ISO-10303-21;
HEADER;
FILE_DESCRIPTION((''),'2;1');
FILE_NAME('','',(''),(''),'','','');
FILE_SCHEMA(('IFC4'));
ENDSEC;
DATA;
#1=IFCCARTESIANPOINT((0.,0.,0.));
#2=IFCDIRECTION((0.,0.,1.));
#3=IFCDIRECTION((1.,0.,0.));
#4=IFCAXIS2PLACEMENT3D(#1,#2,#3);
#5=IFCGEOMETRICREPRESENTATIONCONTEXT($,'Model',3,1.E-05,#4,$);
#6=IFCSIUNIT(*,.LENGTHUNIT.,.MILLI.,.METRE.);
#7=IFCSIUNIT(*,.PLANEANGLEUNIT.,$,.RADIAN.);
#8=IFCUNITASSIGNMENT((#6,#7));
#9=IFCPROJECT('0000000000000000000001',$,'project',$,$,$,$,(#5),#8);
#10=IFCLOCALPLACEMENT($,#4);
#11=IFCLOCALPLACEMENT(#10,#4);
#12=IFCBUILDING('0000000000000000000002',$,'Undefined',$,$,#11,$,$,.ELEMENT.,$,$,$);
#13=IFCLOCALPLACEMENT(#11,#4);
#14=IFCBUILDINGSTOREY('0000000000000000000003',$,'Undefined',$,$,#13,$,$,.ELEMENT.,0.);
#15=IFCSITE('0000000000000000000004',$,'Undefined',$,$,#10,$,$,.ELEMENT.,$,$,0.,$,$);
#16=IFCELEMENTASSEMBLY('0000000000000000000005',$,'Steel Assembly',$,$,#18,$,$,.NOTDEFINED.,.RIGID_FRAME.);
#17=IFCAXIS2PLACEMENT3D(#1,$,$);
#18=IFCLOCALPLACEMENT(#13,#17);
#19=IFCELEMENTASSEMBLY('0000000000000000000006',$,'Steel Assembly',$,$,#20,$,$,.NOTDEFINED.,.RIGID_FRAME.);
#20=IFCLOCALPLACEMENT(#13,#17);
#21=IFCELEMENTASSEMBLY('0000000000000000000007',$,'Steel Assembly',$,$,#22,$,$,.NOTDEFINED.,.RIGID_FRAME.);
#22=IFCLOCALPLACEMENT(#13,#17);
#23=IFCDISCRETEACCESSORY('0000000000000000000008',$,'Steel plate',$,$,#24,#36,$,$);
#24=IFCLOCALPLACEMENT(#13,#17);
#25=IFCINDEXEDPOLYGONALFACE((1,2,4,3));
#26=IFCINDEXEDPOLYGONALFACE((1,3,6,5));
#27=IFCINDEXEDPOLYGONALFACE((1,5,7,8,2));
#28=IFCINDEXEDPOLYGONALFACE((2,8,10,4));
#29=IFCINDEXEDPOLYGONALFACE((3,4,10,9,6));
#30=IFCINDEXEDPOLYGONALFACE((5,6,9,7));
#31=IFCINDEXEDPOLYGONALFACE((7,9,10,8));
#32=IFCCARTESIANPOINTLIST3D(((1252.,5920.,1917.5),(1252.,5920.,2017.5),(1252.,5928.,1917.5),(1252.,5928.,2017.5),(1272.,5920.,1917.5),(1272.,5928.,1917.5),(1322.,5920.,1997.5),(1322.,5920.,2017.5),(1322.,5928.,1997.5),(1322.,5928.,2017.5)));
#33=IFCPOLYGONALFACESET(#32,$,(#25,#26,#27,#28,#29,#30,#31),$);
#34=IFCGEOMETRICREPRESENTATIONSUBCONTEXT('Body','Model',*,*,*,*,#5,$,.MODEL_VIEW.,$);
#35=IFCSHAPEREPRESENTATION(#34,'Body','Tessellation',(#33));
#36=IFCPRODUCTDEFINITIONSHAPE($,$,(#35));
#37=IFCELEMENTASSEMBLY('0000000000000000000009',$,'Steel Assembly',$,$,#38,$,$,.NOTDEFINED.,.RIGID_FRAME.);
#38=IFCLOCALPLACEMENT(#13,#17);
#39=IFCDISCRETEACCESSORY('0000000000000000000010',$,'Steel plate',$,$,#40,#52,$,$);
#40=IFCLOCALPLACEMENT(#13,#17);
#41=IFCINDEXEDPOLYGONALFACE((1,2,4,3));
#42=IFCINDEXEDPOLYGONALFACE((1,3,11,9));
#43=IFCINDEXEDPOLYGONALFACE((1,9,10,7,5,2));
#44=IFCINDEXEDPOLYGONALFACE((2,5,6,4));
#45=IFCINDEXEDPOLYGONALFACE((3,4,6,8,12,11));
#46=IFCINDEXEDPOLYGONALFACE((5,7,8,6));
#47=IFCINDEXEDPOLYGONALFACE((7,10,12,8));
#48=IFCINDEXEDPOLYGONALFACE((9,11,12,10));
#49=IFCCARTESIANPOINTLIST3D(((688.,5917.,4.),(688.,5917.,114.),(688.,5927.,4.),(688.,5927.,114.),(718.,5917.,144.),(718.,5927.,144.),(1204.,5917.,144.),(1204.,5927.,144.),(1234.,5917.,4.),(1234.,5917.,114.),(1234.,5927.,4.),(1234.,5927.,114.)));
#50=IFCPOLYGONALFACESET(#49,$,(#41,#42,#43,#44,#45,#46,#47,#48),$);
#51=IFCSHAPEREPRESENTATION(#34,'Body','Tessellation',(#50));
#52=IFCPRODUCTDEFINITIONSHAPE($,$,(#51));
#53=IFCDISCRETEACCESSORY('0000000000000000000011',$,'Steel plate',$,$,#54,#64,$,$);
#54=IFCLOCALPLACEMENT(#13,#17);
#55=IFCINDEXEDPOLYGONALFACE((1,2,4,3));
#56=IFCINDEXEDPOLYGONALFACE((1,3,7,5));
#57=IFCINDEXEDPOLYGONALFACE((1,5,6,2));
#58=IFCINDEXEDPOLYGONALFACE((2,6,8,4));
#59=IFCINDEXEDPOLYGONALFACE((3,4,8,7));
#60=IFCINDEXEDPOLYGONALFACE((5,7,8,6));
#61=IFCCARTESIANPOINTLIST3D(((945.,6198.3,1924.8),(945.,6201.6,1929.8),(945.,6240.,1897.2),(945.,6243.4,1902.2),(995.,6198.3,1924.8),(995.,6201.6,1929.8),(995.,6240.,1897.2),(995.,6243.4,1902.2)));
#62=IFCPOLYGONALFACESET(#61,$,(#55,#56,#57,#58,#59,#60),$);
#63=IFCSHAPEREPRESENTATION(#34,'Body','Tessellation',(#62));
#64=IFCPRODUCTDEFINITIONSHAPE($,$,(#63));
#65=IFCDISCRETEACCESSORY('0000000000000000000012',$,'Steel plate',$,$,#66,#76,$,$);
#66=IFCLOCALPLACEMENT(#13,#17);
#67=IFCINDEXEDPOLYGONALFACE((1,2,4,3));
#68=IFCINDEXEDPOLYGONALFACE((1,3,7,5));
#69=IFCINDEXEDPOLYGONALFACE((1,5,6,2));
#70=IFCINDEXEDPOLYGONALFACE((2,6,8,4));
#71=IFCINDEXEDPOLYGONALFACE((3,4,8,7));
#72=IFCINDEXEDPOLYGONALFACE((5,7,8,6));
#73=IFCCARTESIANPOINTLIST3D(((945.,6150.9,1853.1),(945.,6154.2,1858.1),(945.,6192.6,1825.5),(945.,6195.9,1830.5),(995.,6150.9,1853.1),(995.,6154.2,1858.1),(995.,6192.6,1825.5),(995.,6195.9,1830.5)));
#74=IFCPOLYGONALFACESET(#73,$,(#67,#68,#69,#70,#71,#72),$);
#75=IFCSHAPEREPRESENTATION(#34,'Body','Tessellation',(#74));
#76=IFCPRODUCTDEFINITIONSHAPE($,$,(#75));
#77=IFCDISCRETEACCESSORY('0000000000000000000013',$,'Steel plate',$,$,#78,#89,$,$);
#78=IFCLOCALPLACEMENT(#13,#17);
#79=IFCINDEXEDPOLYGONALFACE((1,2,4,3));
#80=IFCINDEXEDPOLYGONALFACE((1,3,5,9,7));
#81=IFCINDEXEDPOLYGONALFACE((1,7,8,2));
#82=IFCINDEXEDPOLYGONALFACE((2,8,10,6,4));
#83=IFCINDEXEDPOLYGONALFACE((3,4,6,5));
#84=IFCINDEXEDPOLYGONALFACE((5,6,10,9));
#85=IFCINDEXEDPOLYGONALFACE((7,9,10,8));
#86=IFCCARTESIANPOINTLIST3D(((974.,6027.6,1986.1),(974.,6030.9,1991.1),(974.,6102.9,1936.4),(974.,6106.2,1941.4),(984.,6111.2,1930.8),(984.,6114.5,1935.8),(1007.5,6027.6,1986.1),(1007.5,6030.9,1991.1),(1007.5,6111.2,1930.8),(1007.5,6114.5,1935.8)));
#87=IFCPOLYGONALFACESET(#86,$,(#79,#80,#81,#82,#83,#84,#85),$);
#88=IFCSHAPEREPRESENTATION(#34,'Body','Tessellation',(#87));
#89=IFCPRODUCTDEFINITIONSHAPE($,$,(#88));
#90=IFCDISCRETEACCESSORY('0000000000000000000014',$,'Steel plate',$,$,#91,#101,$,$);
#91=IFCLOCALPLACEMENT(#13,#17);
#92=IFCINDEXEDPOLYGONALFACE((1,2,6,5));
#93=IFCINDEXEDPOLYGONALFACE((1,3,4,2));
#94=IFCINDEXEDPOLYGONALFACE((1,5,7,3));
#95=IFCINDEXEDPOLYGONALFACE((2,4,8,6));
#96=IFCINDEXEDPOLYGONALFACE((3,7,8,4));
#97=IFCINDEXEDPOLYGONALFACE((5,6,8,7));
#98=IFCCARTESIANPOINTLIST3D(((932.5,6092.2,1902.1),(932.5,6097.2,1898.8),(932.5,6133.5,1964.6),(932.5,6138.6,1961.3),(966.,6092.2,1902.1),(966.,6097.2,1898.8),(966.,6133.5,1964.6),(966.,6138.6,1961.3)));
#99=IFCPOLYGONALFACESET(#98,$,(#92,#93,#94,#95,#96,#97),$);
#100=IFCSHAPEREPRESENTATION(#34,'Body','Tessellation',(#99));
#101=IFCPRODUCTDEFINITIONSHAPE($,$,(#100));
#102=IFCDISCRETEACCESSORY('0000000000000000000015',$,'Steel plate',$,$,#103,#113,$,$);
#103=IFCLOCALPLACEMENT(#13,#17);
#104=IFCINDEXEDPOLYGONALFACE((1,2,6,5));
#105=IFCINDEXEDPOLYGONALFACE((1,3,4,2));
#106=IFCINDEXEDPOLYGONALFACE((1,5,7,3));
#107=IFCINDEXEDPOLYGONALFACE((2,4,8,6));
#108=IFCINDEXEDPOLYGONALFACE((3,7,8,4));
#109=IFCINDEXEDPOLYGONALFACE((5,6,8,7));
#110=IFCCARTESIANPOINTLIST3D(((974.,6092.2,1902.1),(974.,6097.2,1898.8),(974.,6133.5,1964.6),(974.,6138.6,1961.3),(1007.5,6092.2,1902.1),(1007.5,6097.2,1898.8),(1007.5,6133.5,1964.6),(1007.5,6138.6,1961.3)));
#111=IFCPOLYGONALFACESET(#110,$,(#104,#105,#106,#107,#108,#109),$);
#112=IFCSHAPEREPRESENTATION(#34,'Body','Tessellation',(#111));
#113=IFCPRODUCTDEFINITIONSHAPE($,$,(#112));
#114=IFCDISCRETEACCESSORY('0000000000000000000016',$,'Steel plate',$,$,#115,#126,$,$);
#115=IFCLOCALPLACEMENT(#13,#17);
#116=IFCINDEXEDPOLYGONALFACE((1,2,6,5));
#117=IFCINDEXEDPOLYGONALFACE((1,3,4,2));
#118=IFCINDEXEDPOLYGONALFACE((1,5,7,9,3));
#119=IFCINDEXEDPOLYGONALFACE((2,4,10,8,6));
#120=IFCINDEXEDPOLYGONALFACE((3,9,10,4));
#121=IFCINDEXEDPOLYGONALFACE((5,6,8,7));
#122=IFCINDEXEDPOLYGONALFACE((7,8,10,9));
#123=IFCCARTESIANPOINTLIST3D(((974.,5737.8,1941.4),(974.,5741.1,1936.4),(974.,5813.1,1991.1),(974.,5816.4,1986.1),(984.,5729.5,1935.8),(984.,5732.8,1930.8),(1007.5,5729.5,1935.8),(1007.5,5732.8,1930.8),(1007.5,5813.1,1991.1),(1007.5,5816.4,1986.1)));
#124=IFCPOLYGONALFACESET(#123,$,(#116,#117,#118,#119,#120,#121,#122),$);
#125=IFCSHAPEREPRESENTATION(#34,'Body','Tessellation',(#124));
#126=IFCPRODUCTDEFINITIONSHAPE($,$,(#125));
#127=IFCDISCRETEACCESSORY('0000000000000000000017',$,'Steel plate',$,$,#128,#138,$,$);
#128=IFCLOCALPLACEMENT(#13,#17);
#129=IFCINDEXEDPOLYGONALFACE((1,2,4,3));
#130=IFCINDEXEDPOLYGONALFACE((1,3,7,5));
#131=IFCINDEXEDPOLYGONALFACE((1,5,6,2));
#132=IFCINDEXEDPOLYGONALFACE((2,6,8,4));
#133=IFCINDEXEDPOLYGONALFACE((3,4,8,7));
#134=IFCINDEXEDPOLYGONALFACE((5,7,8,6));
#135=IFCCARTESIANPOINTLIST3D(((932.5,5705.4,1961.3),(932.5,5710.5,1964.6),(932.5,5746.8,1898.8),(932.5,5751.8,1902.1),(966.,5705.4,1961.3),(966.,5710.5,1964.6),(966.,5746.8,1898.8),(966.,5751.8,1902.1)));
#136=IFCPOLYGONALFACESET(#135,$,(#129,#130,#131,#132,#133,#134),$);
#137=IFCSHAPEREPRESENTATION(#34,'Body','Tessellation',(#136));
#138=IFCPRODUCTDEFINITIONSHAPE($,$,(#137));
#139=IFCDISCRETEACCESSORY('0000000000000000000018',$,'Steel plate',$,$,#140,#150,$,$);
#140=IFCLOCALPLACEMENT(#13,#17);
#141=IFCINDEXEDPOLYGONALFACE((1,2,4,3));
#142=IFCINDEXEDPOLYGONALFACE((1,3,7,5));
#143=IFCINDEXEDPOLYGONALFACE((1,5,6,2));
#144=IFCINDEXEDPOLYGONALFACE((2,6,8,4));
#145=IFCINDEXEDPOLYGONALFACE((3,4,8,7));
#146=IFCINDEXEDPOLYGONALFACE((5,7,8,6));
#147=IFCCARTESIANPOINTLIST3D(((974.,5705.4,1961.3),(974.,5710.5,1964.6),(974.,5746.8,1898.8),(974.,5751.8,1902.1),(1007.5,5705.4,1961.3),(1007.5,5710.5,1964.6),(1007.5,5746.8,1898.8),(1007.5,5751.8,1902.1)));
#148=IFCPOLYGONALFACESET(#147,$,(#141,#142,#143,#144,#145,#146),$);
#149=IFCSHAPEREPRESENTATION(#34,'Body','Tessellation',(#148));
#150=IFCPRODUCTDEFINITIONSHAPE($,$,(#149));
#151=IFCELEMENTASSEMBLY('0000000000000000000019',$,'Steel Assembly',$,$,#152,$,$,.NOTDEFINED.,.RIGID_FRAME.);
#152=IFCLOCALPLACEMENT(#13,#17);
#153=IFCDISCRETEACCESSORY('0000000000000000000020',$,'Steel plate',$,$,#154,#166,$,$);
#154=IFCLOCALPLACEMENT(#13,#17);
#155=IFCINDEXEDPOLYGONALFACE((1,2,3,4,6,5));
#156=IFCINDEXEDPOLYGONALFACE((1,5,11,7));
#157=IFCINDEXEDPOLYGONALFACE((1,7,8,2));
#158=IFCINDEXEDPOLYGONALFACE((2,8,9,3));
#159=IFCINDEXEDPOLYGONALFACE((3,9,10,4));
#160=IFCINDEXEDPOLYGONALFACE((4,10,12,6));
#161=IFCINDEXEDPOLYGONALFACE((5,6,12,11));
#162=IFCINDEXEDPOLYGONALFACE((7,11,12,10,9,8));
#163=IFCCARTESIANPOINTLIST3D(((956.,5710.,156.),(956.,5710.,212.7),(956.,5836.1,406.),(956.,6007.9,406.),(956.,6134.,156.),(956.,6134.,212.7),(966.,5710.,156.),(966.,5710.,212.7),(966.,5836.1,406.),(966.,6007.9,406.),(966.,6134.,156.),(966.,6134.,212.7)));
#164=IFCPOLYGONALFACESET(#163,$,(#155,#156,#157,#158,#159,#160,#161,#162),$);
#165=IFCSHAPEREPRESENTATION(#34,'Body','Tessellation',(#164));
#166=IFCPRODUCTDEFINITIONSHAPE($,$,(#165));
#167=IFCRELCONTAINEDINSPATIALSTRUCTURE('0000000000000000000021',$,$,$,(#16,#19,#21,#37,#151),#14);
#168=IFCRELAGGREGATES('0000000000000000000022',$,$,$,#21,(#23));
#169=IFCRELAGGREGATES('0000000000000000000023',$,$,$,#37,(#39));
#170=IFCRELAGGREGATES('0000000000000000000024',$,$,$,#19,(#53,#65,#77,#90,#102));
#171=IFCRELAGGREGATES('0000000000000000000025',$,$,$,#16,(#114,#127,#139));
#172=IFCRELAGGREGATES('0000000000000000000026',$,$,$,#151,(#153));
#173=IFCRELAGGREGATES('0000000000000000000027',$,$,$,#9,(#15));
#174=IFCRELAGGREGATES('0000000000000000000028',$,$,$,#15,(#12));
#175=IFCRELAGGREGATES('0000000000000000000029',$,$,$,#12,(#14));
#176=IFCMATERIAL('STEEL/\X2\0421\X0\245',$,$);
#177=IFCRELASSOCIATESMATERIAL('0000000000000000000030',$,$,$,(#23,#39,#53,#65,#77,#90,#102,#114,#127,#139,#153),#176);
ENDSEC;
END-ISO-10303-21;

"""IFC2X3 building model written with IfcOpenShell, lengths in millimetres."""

from ifc_helpers import new_model, si_unit, frame, origin_with_axes, place, context, subcontext, project, spatial, polyline, outline, extrude, material, element, aggregate, save


model = new_model("IFC2X3")

# Units and contexts
model_context = context("Model", 3, precision=1e-05, world=origin_with_axes())
body_context = subcontext(model_context, "Body", "Model", "MODEL_VIEW")
ifc_project = project(units=[si_unit("LENGTHUNIT", "METRE", prefix="MILLI"), si_unit("PLANEANGLEUNIT", "RADIAN")], contexts=[model_context])

# Site, building, storey
site_placement = place(None, origin_with_axes())
site = spatial("IfcSite", under=ifc_project, at=site_placement, Name="Undefined", CompositionType="ELEMENT", RefElevation=0.0)
building_placement = place(site_placement, origin_with_axes())
building = spatial("IfcBuilding", under=site, at=building_placement, Name="Undefined", CompositionType="ELEMENT")
storey_placement = place(building_placement, origin_with_axes())
storey = spatial("IfcBuildingStorey", under=building, at=storey_placement, Name="Undefined", CompositionType="ELEMENT", Elevation=0.0)

# Element assemblies
assembly_1_placement = place(storey_placement, origin_with_axes())
assembly_1 = element("IfcElementAssembly", 1, at=assembly_1_placement, inside=storey, Name="Steel Assembly", AssemblyPlace="NOTDEFINED", PredefinedType="RIGID_FRAME")
assembly_2_placement = place(storey_placement, origin_with_axes())
assembly_2 = element("IfcElementAssembly", 2, at=assembly_2_placement, inside=storey, Name="Steel Assembly", AssemblyPlace="NOTDEFINED", PredefinedType="RIGID_FRAME")

# Element assemblies, discrete accessories
assembly_3_placement = place(storey_placement, origin_with_axes())
assembly_3 = element("IfcElementAssembly", 3, at=assembly_3_placement, inside=storey, Name="Steel Assembly", AssemblyPlace="NOTDEFINED", PredefinedType="RIGID_FRAME")
ifc_material_1 = material(Name="STEEL/С245")
discrete_accessory_1_placement = place(assembly_3_placement, frame((1252.0, 5924.0, 2017.5), z_axis=(0.0, -1.0, 0.0), x_axis=(0.0, 0.0, -1.0)))
discrete_accessory_1 = element("IfcDiscreteAccessory", 4, at=discrete_accessory_1_placement, material=ifc_material_1, Name="Steel plate", context=body_context, shape_type="SweptSolid", body=[
    extrude(outline(polyline([(0.0, 0.0), (100.0, 0.0), (100.0, 20.0), (20.0, 70.0), (0.0, 70.0), (0.0, 0.0)])), frame((0.0, 0.0, -4.0), z_axis=(0.0, 0.0, 1.0), x_axis=(1.0, 0.0, 0.0)), (0.0, 0.0, 1.0), 8.0),
])
aggregate(assembly_3, [discrete_accessory_1])
assembly_4_placement = place(storey_placement, origin_with_axes())
assembly_4 = element("IfcElementAssembly", 5, at=assembly_4_placement, inside=storey, Name="Steel Assembly", AssemblyPlace="NOTDEFINED", PredefinedType="RIGID_FRAME")
discrete_accessory_2_placement = place(assembly_4_placement, frame((688.0, 5922.0, 4.0), z_axis=(0.0, 1.0, 0.0), x_axis=(0.0, 0.0, 1.0)))
discrete_accessory_2 = element("IfcDiscreteAccessory", 6, at=discrete_accessory_2_placement, material=ifc_material_1, Name="Steel plate", context=body_context, shape_type="SweptSolid", body=[
    extrude(outline(polyline([(0.0, 0.0), (110.0, 0.0), (140.0, 30.0), (140.0, 516.0), (110.0, 546.0), (0.0, 546.0), (0.0, 0.0)])), frame((0.0, 0.0, -5.0), z_axis=(0.0, 0.0, 1.0), x_axis=(1.0, 0.0, 0.0)), (0.0, 0.0, 1.0), 10.0),
])
aggregate(assembly_4, [discrete_accessory_2])

# Discrete accessories
discrete_accessory_3_placement = place(assembly_2_placement, frame((995.0, 6200.0, 1927.3), z_axis=(0.0, 0.551387, 0.83425), x_axis=(0.0, 0.83425, -0.551387)))
discrete_accessory_3 = element("IfcDiscreteAccessory", 7, at=discrete_accessory_3_placement, material=ifc_material_1, Name="Steel plate", context=body_context, shape_type="SweptSolid", body=[
    extrude(outline(polyline([(0.0, 0.0), (50.0, 0.0), (50.0, 50.0), (0.0, 50.0), (0.0, 0.0)])), frame((0.0, 0.0, -3.0), z_axis=(0.0, 0.0, 1.0), x_axis=(1.0, 0.0, 0.0)), (0.0, 0.0, 1.0), 6.0),
])
discrete_accessory_4_placement = place(assembly_2_placement, frame((995.0, 6152.6, 1855.6), z_axis=(0.0, 0.551387, 0.83425), x_axis=(0.0, 0.83425, -0.551387)))
discrete_accessory_4 = element("IfcDiscreteAccessory", 8, at=discrete_accessory_4_placement, material=ifc_material_1, Name="Steel plate", context=body_context, shape_type="SweptSolid", body=[
    extrude(outline(polyline([(0.0, 0.0), (50.0, 0.0), (50.0, 50.0), (0.0, 50.0), (0.0, 0.0)])), frame((0.0, 0.0, -3.0), z_axis=(0.0, 0.0, 1.0), x_axis=(1.0, 0.0, 0.0)), (0.0, 0.0, 1.0), 6.0),
])
discrete_accessory_5_placement = place(assembly_2_placement, frame((1007.5, 6029.3, 1988.6), z_axis=(0.0, 0.551387, 0.83425), x_axis=(0.0, 0.83425, -0.551387)))
discrete_accessory_5 = element("IfcDiscreteAccessory", 9, at=discrete_accessory_5_placement, material=ifc_material_1, Name="Steel plate", context=body_context, shape_type="SweptSolid", body=[
    extrude(outline(polyline([(0.0, 0.0), (100.2, 0.0), (100.2, 23.5), (90.2, 33.5), (0.0, 33.5), (0.0, 0.0)])), frame((0.0, 0.0, -3.0), z_axis=(0.0, 0.0, 1.0), x_axis=(1.0, 0.0, 0.0)), (0.0, 0.0, 1.0), 6.0),
])

# Discrete accessories, openings
discrete_accessory_6_placement = place(assembly_2_placement, frame((932.5, 6136.1, 1963.0), z_axis=(0.0, -0.83425, 0.551387), x_axis=(0.0, -0.551387, -0.83425)))
discrete_accessory_6 = element("IfcDiscreteAccessory", 10, at=discrete_accessory_6_placement, material=ifc_material_1, Name="Steel plate", context=body_context, shape_type="SweptSolid", body=[
    extrude(outline(polyline([(0.0, 0.0), (75.0, 0.0), (75.0, 75.0), (0.0, 75.0), (0.0, 0.0)])), frame((0.0, 0.0, -3.0), z_axis=(0.0, 0.0, 1.0), x_axis=(1.0, 0.0, 0.0)), (0.0, 0.0, 1.0), 6.0),
])
opening_1_placement = place(assembly_2_placement, frame((932.5, 6136.1, 1963.0), z_axis=(0.0, -0.83425, 0.551387), x_axis=(0.0, -0.551387, -0.83425)))
element("IfcOpeningElement", 11, at=opening_1_placement, cuts=discrete_accessory_6, ObjectType="Recess", context=body_context, shape_type="SweptSolid", body=[
    extrude(outline(polyline([(0.0, 0.0), (75.0, 0.0), (75.0, 150.0), (0.0, 150.0), (0.0, 0.0)])), frame((112.5, 33.5, -6.0), z_axis=(0.0, 0.0, 1.0), x_axis=(0.0, 1.0, 0.0)), (0.0, 0.0, 1.0), 12.0),
])
discrete_accessory_7_placement = place(assembly_2_placement, frame((1007.5, 6094.7, 1900.4), z_axis=(0.0, -0.83425, 0.551387), x_axis=(0.0, 0.551387, 0.83425)))
discrete_accessory_7 = element("IfcDiscreteAccessory", 12, at=discrete_accessory_7_placement, material=ifc_material_1, Name="Steel plate", context=body_context, shape_type="SweptSolid", body=[
    extrude(outline(polyline([(0.0, 0.0), (75.0, 0.0), (75.0, 75.0), (0.0, 75.0), (0.0, 0.0)])), frame((0.0, 0.0, -3.0), z_axis=(0.0, 0.0, 1.0), x_axis=(1.0, 0.0, 0.0)), (0.0, 0.0, 1.0), 6.0),
])
opening_2_placement = place(assembly_2_placement, frame((1007.5, 6094.7, 1900.4), z_axis=(0.0, -0.83425, 0.551387), x_axis=(0.0, 0.551387, 0.83425)))
element("IfcOpeningElement", 13, at=opening_2_placement, cuts=discrete_accessory_7, ObjectType="Recess", context=body_context, shape_type="SweptSolid", body=[
    extrude(outline(polyline([(0.0, 0.0), (75.0, 0.0), (75.0, 150.0), (0.0, 150.0), (0.0, 0.0)])), frame((112.5, 33.5, -6.0), z_axis=(0.0, 0.0, 1.0), x_axis=(0.0, 1.0, 0.0)), (0.0, 0.0, 1.0), 12.0),
])
aggregate(assembly_2, [discrete_accessory_3, discrete_accessory_4, discrete_accessory_5, discrete_accessory_6, discrete_accessory_7])

# Discrete accessory
discrete_accessory_8_placement = place(assembly_1_placement, frame((1007.5, 5731.1, 1933.3), z_axis=(0.0, -0.551387, 0.83425), x_axis=(0.0, 0.83425, 0.551387)))
discrete_accessory_8 = element("IfcDiscreteAccessory", 14, at=discrete_accessory_8_placement, material=ifc_material_1, Name="Steel plate", context=body_context, shape_type="SweptSolid", body=[
    extrude(outline(polyline([(0.0, 0.0), (100.2, 0.0), (100.2, 33.5), (10.0, 33.5), (0.0, 23.5), (0.0, 0.0)])), frame((0.0, 0.0, -3.0), z_axis=(0.0, 0.0, 1.0), x_axis=(1.0, 0.0, 0.0)), (0.0, 0.0, 1.0), 6.0),
])

# Discrete accessories, openings
discrete_accessory_9_placement = place(assembly_1_placement, frame((932.5, 5749.3, 1900.4), z_axis=(0.0, 0.83425, 0.551387), x_axis=(0.0, -0.551387, 0.83425)))
discrete_accessory_9 = element("IfcDiscreteAccessory", 15, at=discrete_accessory_9_placement, material=ifc_material_1, Name="Steel plate", context=body_context, shape_type="SweptSolid", body=[
    extrude(outline(polyline([(0.0, 0.0), (75.0, 0.0), (75.0, 75.0), (0.0, 75.0), (0.0, 0.0)])), frame((0.0, 0.0, -3.0), z_axis=(0.0, 0.0, 1.0), x_axis=(1.0, 0.0, 0.0)), (0.0, 0.0, 1.0), 6.0),
])
opening_3_placement = place(assembly_1_placement, frame((932.5, 5749.3, 1900.4), z_axis=(0.0, 0.83425, 0.551387), x_axis=(0.0, -0.551387, 0.83425)))
element("IfcOpeningElement", 16, at=opening_3_placement, cuts=discrete_accessory_9, ObjectType="Recess", context=body_context, shape_type="SweptSolid", body=[
    extrude(outline(polyline([(0.0, 0.0), (75.0, 0.0), (75.0, 150.0), (0.0, 150.0), (0.0, 0.0)])), frame((112.5, 33.5, -6.0), z_axis=(0.0, 0.0, 1.0), x_axis=(0.0, 1.0, 0.0)), (0.0, 0.0, 1.0), 12.0),
])
discrete_accessory_10_placement = place(assembly_1_placement, frame((1007.5, 5707.9, 1963.0), z_axis=(0.0, 0.83425, 0.551387), x_axis=(0.0, 0.551387, -0.83425)))
discrete_accessory_10 = element("IfcDiscreteAccessory", 17, at=discrete_accessory_10_placement, material=ifc_material_1, Name="Steel plate", context=body_context, shape_type="SweptSolid", body=[
    extrude(outline(polyline([(0.0, 0.0), (75.0, 0.0), (75.0, 75.0), (0.0, 75.0), (0.0, 0.0)])), frame((0.0, 0.0, -3.0), z_axis=(0.0, 0.0, 1.0), x_axis=(1.0, 0.0, 0.0)), (0.0, 0.0, 1.0), 6.0),
])
opening_4_placement = place(assembly_1_placement, frame((1007.5, 5707.9, 1963.0), z_axis=(0.0, 0.83425, 0.551387), x_axis=(0.0, 0.551387, -0.83425)))
element("IfcOpeningElement", 18, at=opening_4_placement, cuts=discrete_accessory_10, ObjectType="Recess", context=body_context, shape_type="SweptSolid", body=[
    extrude(outline(polyline([(0.0, 0.0), (75.0, 0.0), (75.0, 150.0), (0.0, 150.0), (0.0, 0.0)])), frame((112.5, 33.5, -6.0), z_axis=(0.0, 0.0, 1.0), x_axis=(0.0, 1.0, 0.0)), (0.0, 0.0, 1.0), 12.0),
])
aggregate(assembly_1, [discrete_accessory_8, discrete_accessory_9, discrete_accessory_10])

# Element assembly, discrete accessory
assembly_5_placement = place(storey_placement, origin_with_axes())
assembly_5 = element("IfcElementAssembly", 19, at=assembly_5_placement, inside=storey, Name="Steel Assembly", AssemblyPlace="NOTDEFINED", PredefinedType="RIGID_FRAME")
discrete_accessory_11_placement = place(assembly_5_placement, frame((961.0, 5710.0, 156.0), z_axis=(1.0, 0.0, 0.0), x_axis=(0.0, 1.0, 0.0)))
discrete_accessory_11 = element("IfcDiscreteAccessory", 20, at=discrete_accessory_11_placement, material=ifc_material_1, Name="Steel plate", context=body_context, shape_type="SweptSolid", body=[
    extrude(outline(polyline([(0.0, 0.0), (424.0, 0.0), (424.0, 56.7), (297.9, 250.0), (126.1, 250.0), (0.0, 56.7), (0.0, 0.0)])), frame((0.0, 0.0, -5.0), z_axis=(0.0, 0.0, 1.0), x_axis=(1.0, 0.0, 0.0)), (0.0, 0.0, 1.0), 10.0),
])
aggregate(assembly_5, [discrete_accessory_11])

save(model, "model.ifc")
